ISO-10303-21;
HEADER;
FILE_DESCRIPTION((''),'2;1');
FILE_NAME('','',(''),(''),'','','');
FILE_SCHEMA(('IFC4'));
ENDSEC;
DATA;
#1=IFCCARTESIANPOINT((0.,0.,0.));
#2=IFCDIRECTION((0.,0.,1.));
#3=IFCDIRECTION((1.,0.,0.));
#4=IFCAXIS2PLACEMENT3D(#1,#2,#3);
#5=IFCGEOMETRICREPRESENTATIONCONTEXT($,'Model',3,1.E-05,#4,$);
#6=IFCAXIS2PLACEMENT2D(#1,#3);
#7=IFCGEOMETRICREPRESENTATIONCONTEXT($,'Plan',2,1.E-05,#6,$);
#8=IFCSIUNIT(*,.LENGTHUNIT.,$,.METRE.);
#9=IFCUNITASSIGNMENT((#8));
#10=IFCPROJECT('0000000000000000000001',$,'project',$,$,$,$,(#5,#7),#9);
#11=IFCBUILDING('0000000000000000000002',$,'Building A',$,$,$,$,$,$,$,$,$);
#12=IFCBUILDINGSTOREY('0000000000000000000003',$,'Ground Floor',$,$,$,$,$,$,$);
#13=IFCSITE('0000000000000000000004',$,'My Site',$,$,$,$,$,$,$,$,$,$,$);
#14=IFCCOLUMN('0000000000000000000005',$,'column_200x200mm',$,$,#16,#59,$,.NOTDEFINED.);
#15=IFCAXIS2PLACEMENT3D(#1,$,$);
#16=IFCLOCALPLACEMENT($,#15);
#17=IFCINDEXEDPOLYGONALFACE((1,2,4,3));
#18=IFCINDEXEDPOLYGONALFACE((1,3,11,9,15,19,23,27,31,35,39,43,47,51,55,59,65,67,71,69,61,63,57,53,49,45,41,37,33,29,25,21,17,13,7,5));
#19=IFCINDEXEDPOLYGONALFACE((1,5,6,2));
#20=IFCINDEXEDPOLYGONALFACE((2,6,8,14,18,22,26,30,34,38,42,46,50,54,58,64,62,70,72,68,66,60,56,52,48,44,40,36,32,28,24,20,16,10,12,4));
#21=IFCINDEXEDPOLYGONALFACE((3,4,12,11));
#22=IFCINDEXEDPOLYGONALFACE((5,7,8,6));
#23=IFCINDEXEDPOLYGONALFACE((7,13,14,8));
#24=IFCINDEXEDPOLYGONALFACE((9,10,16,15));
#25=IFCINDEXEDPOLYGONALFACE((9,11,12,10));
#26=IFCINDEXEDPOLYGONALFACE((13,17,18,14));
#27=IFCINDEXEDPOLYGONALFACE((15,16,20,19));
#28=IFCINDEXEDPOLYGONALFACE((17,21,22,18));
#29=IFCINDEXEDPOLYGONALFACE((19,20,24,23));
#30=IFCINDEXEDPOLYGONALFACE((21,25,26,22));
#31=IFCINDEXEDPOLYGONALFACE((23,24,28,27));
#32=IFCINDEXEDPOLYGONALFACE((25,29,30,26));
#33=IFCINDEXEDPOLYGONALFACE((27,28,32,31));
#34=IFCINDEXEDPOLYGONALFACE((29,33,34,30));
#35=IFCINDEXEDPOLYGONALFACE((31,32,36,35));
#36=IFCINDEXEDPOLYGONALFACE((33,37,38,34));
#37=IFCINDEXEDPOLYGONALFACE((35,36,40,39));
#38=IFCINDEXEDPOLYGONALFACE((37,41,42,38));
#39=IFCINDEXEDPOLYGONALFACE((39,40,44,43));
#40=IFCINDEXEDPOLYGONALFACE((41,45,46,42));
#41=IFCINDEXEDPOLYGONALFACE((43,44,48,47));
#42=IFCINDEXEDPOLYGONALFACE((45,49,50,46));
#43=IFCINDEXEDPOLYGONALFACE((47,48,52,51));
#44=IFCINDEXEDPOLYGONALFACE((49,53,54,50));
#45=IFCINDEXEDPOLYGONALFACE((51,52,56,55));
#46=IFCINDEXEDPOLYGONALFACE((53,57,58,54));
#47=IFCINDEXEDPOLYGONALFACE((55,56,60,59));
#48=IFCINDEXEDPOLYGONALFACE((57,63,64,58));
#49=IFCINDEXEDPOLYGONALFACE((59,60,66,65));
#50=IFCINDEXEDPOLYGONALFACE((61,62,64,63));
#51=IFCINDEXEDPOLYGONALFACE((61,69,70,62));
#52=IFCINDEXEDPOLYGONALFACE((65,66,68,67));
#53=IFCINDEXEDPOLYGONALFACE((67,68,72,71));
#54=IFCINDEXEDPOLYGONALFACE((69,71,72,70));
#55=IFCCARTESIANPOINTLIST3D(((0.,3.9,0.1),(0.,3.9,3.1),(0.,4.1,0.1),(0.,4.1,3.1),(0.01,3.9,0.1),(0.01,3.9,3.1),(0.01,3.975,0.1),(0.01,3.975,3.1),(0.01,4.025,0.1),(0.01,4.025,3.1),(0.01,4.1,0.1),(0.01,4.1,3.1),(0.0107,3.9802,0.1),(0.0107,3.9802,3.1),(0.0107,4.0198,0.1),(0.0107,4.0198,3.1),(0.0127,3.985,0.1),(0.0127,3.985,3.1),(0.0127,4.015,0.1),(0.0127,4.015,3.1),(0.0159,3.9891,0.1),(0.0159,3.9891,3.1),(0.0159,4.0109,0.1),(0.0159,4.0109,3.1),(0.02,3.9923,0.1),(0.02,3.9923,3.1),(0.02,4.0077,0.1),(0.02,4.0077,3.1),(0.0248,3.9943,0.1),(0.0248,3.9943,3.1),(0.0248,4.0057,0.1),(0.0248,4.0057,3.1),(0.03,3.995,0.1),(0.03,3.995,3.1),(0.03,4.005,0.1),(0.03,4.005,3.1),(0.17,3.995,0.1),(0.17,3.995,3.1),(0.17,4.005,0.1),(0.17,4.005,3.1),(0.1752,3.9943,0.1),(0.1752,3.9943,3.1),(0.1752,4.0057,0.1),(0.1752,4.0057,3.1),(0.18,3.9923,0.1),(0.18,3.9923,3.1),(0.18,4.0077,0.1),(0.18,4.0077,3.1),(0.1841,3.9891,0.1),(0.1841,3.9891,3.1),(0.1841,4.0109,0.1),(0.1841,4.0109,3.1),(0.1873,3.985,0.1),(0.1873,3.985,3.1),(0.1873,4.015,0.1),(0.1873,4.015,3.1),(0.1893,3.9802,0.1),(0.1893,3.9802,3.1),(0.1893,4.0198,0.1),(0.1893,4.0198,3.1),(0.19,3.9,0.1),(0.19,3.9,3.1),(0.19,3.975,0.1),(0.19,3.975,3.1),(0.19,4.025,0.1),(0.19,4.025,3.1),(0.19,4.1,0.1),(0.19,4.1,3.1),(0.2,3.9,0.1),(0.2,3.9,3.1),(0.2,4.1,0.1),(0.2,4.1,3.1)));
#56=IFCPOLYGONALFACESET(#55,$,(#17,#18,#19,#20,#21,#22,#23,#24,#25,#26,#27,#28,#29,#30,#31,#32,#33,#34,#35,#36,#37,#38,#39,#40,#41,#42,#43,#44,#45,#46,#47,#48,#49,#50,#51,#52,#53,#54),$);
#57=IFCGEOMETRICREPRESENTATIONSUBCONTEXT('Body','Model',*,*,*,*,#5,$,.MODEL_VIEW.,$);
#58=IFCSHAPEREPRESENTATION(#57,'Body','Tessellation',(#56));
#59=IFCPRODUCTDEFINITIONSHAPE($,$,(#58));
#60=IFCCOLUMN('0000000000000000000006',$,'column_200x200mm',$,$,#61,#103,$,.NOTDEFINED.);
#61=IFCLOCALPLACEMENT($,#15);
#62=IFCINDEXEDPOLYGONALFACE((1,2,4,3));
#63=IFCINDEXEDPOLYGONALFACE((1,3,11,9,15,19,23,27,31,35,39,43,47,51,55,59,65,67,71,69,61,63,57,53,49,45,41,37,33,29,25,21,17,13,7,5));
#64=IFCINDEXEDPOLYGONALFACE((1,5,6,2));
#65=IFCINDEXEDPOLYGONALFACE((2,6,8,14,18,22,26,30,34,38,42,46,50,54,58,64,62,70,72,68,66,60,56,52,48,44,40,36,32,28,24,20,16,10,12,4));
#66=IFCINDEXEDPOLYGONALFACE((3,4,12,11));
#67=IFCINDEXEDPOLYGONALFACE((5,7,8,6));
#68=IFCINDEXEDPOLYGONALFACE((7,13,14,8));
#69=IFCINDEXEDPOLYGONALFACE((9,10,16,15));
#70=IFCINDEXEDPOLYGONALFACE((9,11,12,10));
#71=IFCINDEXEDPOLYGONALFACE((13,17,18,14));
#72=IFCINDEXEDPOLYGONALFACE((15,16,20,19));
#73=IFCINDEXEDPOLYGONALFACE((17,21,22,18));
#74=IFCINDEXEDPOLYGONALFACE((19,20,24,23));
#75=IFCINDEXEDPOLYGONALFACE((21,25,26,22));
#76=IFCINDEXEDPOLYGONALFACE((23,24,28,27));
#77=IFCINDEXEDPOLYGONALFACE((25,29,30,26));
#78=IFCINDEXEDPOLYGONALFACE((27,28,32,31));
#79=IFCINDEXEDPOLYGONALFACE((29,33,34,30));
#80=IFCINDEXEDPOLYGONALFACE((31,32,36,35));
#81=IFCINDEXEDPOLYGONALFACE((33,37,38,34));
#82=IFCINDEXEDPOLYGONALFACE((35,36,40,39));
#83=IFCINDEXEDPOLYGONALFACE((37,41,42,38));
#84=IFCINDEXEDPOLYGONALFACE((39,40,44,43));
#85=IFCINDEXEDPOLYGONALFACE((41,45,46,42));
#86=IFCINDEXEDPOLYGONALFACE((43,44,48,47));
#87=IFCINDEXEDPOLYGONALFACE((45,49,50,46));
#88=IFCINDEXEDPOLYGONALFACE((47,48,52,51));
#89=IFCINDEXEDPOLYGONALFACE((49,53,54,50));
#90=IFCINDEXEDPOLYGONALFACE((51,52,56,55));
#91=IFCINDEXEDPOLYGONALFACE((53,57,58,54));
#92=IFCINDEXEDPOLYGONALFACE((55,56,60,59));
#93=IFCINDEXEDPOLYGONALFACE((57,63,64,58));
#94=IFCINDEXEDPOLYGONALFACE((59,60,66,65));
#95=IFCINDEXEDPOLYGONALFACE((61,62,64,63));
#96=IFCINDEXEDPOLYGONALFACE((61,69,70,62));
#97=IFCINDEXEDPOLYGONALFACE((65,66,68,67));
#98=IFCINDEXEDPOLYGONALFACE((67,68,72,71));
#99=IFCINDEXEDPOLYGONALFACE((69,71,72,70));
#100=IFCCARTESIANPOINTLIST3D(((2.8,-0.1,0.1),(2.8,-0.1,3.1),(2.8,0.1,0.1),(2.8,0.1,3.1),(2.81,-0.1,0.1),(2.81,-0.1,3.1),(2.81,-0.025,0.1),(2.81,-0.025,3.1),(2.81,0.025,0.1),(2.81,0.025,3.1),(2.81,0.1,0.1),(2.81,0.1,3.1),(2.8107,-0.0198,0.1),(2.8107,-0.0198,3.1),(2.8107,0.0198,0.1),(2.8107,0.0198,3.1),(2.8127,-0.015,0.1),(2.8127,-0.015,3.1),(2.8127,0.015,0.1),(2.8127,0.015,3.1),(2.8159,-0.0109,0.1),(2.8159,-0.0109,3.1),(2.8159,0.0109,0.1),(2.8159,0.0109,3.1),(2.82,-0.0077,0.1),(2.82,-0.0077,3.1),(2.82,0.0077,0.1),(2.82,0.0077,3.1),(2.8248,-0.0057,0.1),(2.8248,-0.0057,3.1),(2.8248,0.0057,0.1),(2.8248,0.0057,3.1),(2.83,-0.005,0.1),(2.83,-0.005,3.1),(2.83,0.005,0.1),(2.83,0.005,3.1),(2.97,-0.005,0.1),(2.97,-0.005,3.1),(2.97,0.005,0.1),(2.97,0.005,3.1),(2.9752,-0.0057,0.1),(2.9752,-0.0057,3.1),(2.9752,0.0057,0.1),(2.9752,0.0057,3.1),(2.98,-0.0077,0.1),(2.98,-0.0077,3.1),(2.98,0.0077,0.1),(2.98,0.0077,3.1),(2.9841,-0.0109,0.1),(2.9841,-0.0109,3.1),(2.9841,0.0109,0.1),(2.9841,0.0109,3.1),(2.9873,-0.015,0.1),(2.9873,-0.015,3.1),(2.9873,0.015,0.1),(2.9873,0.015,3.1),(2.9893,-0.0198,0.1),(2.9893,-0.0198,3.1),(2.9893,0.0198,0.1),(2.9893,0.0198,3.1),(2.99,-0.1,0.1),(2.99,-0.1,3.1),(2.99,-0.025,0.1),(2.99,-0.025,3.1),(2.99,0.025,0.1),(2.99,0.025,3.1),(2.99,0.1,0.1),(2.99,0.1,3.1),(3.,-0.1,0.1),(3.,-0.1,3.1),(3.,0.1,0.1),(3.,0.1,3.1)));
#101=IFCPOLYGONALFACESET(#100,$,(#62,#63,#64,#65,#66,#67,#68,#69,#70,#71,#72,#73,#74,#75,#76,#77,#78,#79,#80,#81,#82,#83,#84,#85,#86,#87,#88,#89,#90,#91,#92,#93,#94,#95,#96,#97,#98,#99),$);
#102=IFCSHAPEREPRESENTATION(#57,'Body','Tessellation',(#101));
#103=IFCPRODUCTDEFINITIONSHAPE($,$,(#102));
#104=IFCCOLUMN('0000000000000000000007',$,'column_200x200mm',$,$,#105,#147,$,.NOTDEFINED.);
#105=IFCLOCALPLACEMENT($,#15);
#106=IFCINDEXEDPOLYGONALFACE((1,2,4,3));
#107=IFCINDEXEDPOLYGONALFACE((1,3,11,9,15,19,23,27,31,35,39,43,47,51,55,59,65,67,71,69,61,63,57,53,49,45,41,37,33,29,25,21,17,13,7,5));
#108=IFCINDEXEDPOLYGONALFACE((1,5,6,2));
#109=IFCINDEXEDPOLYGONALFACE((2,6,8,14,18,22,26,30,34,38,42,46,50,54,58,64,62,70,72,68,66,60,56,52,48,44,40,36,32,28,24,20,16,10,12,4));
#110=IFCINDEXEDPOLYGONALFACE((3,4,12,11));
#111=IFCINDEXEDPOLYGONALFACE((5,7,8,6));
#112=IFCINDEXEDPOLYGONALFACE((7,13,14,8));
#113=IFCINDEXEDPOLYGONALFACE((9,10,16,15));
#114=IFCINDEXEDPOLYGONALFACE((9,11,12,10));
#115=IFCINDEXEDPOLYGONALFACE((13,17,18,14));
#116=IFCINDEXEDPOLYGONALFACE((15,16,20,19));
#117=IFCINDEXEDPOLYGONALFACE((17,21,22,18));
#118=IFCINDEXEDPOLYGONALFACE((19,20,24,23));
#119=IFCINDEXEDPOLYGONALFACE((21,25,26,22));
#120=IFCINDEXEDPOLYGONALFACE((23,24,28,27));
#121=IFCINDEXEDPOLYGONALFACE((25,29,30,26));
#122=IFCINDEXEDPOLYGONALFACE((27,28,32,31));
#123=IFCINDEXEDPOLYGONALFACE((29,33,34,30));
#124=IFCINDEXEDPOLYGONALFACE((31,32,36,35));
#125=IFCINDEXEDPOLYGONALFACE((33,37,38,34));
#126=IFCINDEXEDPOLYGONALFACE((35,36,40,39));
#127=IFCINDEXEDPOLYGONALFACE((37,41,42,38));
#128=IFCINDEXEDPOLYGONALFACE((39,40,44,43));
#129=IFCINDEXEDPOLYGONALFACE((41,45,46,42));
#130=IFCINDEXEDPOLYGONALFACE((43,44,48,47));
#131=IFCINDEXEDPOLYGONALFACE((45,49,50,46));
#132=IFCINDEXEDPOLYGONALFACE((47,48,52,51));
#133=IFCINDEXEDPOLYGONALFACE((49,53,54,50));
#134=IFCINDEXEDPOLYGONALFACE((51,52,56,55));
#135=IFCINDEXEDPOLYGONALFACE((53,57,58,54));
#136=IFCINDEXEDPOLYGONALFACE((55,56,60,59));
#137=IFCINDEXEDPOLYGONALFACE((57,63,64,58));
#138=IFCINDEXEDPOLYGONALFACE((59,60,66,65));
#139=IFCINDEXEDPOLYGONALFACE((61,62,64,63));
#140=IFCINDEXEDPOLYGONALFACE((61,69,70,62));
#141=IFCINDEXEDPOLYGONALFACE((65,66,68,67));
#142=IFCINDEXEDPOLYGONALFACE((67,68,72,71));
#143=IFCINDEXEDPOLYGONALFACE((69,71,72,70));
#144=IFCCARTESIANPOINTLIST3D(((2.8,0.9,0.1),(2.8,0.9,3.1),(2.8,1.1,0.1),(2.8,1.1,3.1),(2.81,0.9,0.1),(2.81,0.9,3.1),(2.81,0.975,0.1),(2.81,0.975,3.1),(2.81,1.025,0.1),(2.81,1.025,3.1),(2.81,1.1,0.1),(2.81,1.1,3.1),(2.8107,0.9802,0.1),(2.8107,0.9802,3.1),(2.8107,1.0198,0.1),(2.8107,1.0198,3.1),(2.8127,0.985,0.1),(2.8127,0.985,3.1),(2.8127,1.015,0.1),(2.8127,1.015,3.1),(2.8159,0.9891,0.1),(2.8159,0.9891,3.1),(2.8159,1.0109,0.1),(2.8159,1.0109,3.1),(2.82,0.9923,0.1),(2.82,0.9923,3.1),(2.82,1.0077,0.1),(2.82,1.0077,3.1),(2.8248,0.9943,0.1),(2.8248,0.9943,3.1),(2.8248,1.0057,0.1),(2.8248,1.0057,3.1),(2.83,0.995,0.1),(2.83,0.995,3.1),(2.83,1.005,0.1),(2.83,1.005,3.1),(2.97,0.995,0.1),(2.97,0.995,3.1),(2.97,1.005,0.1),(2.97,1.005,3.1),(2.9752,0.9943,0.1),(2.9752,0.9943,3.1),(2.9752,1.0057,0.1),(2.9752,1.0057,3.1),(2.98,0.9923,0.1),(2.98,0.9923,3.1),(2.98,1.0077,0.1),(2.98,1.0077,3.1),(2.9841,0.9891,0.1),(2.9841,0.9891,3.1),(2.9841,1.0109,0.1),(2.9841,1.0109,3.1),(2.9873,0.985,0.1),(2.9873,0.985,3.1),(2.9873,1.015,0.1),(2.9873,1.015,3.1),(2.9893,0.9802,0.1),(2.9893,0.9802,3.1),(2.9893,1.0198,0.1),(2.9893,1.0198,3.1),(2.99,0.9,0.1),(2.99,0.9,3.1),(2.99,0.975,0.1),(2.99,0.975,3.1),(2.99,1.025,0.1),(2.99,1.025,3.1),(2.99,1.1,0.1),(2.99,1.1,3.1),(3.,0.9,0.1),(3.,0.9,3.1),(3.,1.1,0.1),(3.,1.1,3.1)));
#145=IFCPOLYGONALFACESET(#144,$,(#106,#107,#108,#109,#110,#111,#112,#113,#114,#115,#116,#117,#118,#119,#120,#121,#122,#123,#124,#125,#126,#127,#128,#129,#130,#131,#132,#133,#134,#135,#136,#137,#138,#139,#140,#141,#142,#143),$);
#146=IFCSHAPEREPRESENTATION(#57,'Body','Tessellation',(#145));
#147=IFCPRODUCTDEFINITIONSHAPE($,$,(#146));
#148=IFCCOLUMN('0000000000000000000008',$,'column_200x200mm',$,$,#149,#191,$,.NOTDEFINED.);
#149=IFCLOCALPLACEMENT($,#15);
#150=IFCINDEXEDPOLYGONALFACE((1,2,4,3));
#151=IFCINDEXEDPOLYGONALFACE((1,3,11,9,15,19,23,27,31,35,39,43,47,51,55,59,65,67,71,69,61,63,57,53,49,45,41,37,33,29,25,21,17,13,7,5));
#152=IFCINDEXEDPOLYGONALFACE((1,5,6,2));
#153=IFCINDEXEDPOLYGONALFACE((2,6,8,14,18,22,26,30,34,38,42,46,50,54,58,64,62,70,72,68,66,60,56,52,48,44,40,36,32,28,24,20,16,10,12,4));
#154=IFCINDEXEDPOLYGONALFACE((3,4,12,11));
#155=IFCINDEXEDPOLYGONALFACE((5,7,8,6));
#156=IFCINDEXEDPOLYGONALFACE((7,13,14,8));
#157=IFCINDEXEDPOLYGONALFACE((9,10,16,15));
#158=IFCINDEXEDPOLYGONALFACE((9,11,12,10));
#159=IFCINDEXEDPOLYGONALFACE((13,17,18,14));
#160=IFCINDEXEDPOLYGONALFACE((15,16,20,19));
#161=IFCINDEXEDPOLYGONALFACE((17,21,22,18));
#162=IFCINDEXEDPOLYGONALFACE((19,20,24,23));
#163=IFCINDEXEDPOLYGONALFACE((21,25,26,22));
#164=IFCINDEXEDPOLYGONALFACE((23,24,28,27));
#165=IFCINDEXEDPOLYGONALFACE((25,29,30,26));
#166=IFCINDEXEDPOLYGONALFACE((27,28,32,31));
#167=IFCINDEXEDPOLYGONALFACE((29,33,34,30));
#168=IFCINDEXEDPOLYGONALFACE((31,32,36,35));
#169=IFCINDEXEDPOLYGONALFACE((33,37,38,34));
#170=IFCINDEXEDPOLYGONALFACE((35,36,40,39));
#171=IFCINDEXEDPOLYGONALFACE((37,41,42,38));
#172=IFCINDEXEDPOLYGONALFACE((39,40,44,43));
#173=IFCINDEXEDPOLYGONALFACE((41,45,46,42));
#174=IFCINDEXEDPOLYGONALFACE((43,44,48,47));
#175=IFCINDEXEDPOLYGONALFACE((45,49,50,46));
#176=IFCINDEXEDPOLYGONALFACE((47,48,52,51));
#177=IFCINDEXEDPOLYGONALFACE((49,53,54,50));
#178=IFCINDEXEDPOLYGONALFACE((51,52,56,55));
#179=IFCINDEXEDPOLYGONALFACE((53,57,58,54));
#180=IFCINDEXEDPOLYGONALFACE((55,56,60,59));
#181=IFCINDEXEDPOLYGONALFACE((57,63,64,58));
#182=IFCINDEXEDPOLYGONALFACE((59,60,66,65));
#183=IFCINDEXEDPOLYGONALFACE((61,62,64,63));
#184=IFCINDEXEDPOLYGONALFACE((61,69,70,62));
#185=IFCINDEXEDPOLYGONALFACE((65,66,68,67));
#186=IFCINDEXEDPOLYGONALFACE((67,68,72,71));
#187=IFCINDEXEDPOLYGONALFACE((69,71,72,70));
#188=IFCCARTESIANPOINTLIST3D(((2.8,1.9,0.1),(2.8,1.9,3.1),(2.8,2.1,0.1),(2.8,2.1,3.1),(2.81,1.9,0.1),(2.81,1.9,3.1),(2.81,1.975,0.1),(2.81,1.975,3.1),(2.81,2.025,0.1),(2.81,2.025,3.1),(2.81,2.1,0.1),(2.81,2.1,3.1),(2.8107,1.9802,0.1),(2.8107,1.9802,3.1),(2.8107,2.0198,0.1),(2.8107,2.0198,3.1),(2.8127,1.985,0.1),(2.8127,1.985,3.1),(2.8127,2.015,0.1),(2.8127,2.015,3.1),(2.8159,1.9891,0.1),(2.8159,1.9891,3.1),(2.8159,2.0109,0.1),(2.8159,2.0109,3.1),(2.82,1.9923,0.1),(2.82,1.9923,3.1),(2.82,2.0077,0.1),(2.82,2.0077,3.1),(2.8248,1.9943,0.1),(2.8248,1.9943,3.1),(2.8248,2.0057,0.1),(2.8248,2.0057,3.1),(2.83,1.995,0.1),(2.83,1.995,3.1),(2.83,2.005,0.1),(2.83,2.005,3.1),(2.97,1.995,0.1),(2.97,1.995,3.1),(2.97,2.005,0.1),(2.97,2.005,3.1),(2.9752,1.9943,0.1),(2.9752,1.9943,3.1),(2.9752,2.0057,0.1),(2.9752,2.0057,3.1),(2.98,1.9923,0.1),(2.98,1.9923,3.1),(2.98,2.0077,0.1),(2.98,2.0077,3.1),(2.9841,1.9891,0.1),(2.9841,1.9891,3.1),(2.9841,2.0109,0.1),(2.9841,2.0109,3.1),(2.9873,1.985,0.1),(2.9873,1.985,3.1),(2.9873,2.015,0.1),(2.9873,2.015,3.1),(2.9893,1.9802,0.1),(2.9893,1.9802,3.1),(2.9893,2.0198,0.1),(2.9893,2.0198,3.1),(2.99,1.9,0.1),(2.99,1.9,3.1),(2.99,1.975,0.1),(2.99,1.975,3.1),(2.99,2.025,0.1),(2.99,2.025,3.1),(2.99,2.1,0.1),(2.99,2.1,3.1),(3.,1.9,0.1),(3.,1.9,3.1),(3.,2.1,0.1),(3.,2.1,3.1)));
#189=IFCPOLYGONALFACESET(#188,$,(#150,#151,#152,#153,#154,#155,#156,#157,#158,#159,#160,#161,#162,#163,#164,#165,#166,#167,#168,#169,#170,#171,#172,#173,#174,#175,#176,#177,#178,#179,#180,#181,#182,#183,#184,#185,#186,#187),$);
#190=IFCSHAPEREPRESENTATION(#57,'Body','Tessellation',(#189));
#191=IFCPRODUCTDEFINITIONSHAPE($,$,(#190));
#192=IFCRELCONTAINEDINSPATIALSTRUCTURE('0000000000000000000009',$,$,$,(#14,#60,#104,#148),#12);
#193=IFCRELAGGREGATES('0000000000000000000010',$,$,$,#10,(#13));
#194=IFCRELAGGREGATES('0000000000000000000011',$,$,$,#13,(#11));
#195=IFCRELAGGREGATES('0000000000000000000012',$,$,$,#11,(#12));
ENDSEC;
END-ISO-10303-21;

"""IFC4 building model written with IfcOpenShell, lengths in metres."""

from ifc_helpers import new_model, entity, si_unit, frame, frame_2d, origin_with_axes, place, context, subcontext, project, spatial, extrude, element, save


model = new_model("IFC4")

# Units and contexts
model_context = context("Model", 3, precision=1e-05, world=origin_with_axes())
plan_context = context("Plan", 2, precision=1e-05, world=frame_2d((0.0, 0.0, 0.0), x_axis=(1.0, 0.0, 0.0)))
body_context = subcontext(model_context, "Body", "Model", "MODEL_VIEW")
ifc_project = project(units=[si_unit("LENGTHUNIT", "METRE")], contexts=[model_context, plan_context])

# Site, building, storey
site = spatial("IfcSite", under=ifc_project, Name="My Site")
building = spatial("IfcBuilding", under=site, Name="Building A")
storey = spatial("IfcBuildingStorey", under=building, Name="Ground Floor")

# Columns
for number, where, z_axis, x_axis, name in (
    (1, (0.1, 4.0, 0.1), (0.0, 0.0, 1.0), (0.0, 1.0, 0.0), "column_200x200mm"),
    (2, (2.9, 0.0, 0.1), (0.0, 0.0, 1.0), (0.0, 1.0, 0.0), "column_200x200mm"),
    (3, (2.9, 1.0, 0.1), (0.0, 0.0, 1.0), (0.0, 1.0, 0.0), "column_200x200mm"),
    (4, (2.9, 2.0, 0.1), (0.0, 0.0, 1.0), (0.0, 1.0, 0.0), "column_200x200mm"),
):
    element("IfcColumn", number, at=place(None, frame(where, z_axis=z_axis, x_axis=x_axis)), inside=storey, Name=name, PredefinedType="NOTDEFINED", context=body_context, shape_type="SweptSolid", body=[
        extrude(entity("IfcIShapeProfileDef", None, None, None, 0.2, 0.2, 0.01, 0.01, 0.02), origin_with_axes(), (0.0, 0.0, 1.0), 3.0),
    ])

save(model, "model.ifc")
